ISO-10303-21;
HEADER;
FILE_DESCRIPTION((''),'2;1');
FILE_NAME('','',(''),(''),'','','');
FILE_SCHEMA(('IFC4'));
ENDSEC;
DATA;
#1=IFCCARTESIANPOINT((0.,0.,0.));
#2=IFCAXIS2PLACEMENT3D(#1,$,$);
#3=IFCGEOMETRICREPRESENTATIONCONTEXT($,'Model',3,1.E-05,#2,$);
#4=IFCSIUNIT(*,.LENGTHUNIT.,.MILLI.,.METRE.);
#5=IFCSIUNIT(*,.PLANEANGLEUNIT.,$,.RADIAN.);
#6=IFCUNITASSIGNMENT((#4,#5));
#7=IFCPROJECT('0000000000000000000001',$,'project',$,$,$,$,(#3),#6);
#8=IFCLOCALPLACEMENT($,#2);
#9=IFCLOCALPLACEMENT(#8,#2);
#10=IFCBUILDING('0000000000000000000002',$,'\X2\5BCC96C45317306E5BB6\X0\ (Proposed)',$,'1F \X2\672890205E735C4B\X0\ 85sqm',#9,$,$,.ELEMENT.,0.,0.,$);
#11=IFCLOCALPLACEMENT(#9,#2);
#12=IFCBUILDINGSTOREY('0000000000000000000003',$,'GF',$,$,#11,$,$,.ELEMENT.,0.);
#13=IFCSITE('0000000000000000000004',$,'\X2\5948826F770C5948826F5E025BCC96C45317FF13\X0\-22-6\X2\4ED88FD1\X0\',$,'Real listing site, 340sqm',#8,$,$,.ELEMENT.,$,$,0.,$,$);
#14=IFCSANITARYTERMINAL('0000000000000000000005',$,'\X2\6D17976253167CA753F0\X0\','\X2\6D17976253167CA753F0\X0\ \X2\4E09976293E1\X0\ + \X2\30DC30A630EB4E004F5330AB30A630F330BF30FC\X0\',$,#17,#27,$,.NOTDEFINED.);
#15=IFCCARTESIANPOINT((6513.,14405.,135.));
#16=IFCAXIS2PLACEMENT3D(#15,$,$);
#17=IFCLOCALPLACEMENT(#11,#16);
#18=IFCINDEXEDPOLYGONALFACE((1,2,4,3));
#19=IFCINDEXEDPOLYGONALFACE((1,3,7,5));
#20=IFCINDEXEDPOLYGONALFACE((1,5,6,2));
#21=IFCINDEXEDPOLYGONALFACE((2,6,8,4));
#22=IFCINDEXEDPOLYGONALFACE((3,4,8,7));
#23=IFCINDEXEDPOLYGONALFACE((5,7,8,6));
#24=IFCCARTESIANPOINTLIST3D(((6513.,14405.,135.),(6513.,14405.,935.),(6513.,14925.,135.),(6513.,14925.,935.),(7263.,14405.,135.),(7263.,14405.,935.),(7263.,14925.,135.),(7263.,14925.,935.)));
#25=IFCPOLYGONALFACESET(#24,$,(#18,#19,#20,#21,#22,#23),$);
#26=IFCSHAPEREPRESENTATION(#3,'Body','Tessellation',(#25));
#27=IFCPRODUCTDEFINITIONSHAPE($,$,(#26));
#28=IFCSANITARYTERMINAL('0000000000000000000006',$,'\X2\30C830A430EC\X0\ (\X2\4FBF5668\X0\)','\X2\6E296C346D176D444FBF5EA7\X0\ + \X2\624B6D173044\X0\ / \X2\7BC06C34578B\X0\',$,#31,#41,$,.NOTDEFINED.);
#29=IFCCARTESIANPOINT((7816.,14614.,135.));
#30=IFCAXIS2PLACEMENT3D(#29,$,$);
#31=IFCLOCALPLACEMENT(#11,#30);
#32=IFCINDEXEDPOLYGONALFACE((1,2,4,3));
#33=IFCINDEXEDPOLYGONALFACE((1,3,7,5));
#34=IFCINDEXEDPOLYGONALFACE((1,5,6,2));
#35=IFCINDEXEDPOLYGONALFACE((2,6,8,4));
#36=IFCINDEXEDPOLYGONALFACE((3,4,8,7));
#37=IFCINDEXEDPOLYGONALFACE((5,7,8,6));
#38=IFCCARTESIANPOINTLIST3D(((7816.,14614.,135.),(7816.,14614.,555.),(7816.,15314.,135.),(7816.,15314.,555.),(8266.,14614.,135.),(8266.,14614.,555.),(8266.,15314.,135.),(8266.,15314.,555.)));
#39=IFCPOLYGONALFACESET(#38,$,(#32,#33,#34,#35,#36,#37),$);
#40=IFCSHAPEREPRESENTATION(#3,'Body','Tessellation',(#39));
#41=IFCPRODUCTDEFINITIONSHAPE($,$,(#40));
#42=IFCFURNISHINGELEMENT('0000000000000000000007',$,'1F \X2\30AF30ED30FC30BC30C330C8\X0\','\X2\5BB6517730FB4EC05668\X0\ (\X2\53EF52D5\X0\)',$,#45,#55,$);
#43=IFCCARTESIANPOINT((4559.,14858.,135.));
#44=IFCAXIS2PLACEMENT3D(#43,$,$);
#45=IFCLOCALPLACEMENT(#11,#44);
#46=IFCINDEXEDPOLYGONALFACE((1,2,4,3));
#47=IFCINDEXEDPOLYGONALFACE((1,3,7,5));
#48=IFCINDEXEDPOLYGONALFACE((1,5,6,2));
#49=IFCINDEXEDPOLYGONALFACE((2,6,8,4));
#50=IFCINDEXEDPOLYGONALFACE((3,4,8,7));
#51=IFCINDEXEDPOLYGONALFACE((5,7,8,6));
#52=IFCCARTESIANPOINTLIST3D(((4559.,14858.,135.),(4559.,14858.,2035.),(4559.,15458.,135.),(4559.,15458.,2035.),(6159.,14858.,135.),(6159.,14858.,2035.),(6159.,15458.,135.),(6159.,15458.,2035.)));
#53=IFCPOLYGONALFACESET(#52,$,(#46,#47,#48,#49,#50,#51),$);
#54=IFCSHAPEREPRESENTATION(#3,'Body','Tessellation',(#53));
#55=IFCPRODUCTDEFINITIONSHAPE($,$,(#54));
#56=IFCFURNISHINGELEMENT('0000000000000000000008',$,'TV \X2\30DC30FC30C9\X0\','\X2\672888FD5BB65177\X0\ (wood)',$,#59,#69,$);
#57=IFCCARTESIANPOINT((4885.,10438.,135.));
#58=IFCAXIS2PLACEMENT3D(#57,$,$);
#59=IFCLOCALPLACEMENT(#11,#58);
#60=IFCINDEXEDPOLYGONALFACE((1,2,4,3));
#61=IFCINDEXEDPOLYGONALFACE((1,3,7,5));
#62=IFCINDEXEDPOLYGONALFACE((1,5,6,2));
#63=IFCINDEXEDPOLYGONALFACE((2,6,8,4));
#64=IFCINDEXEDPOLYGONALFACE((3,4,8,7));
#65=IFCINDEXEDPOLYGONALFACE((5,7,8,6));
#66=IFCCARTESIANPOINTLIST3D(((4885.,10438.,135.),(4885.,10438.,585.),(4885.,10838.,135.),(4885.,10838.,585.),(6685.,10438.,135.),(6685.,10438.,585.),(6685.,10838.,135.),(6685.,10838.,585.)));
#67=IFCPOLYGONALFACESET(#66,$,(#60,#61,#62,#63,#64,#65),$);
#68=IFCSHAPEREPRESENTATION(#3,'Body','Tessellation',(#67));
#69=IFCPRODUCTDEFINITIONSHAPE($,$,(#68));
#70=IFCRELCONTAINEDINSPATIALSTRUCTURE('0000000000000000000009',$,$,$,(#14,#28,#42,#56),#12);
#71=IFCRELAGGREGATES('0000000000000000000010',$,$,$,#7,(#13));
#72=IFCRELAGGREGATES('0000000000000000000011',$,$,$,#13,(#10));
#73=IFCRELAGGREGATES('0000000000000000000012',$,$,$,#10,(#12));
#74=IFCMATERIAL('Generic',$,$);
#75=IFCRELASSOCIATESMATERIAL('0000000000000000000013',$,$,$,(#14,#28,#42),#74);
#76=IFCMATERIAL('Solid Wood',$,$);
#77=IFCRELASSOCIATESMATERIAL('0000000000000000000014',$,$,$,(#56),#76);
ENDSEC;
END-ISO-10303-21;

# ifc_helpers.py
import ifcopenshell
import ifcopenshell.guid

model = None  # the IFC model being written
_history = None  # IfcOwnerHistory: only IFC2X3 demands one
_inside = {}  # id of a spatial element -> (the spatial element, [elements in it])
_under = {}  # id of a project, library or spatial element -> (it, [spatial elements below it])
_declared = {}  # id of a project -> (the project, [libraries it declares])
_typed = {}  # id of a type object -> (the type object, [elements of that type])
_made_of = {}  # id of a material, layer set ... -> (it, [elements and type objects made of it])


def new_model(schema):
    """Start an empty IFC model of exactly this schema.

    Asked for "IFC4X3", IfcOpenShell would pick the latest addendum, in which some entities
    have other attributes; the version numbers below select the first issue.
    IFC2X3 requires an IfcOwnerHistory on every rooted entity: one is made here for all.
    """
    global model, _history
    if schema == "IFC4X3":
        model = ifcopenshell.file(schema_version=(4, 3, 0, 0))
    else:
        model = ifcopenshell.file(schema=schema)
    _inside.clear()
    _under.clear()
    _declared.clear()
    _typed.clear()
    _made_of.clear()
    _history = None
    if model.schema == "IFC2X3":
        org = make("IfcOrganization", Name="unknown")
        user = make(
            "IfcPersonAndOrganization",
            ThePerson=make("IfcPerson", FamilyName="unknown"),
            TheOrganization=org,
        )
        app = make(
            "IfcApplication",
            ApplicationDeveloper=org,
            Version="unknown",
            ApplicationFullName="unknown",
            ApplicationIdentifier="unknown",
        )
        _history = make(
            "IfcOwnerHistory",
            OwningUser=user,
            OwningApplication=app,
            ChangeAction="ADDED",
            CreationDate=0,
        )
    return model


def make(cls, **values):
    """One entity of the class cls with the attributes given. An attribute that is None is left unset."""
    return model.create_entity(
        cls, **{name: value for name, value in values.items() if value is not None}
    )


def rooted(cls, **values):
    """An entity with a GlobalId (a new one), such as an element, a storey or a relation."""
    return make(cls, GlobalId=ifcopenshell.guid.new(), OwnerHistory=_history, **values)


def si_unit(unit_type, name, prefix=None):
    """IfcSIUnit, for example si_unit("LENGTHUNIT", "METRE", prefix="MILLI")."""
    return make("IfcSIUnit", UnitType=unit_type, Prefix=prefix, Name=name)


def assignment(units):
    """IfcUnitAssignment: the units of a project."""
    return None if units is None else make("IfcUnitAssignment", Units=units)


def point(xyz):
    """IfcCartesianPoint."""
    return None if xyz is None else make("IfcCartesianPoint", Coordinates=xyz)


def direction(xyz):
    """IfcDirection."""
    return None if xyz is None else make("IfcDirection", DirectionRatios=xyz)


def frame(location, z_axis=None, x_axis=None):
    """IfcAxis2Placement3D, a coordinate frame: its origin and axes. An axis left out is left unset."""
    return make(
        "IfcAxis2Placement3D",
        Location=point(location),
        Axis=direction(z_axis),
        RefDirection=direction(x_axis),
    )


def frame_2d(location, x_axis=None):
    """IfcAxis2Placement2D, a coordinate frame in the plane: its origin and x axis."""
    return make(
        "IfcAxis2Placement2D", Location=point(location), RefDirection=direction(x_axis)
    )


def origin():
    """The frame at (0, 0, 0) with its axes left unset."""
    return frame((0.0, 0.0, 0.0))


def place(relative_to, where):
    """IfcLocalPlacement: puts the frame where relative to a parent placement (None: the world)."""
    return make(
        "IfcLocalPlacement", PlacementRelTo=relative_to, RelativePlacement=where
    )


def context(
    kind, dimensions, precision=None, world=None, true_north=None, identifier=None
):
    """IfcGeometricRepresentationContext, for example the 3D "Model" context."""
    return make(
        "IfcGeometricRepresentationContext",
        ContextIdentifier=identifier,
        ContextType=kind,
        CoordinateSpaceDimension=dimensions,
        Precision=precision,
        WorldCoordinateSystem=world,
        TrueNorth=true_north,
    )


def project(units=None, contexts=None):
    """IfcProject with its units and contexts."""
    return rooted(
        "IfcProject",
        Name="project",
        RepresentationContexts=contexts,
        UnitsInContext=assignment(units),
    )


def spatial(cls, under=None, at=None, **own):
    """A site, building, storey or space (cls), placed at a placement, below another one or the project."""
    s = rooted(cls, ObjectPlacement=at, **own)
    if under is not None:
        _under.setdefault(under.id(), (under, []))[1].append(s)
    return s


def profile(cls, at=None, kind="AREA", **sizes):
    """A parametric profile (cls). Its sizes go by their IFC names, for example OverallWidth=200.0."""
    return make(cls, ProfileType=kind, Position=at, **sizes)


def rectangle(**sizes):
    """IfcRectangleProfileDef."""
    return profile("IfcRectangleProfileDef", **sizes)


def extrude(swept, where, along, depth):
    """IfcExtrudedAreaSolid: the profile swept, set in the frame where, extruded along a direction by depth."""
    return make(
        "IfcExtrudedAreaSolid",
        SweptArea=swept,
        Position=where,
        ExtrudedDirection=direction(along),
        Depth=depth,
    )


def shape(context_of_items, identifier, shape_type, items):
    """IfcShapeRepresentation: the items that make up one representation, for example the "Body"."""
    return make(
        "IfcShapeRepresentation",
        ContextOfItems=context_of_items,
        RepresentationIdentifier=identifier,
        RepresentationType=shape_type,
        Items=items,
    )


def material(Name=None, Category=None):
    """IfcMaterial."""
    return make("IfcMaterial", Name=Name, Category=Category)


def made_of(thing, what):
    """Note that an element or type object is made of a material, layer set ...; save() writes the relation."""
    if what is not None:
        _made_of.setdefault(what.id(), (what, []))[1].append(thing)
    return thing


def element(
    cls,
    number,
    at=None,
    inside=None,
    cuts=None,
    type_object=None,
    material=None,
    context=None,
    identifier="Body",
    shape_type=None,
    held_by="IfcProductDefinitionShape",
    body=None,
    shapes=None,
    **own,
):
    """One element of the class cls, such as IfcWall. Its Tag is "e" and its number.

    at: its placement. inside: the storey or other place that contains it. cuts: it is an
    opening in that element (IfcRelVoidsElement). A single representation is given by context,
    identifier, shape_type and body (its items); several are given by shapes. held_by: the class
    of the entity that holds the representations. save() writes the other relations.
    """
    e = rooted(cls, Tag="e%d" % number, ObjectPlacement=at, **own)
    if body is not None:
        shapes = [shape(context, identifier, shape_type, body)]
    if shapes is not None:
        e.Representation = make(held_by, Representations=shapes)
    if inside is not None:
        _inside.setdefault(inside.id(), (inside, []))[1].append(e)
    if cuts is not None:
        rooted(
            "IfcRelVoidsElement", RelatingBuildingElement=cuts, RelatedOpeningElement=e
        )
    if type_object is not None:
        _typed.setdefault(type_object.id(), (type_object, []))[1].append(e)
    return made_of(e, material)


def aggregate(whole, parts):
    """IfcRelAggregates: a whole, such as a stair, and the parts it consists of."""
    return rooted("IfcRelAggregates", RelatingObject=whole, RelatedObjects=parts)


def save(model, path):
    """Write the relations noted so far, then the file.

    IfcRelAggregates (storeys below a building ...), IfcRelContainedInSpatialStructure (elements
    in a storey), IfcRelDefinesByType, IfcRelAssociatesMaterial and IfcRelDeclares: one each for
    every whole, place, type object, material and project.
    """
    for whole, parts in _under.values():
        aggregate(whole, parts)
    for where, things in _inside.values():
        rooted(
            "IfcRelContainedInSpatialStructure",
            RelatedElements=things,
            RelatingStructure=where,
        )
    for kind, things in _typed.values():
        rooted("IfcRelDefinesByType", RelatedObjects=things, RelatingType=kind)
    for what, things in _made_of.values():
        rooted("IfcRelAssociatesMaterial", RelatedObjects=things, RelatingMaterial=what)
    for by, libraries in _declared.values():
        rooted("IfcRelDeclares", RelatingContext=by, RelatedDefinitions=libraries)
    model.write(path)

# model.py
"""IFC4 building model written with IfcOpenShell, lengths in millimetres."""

from ifc_helpers import new_model, si_unit, frame, frame_2d, origin, place, context, project, spatial, rectangle, extrude, material, element, save


model = new_model("IFC4")

# Units and contexts
model_context = context("Model", 3, precision=1e-05, world=origin())
ifc_project = project(units=[si_unit("LENGTHUNIT", "METRE", prefix="MILLI"), si_unit("PLANEANGLEUNIT", "RADIAN")], contexts=[model_context])

# Site, building, storey
site_placement = place(None, origin())
site = spatial("IfcSite", under=ifc_project, at=site_placement, Name="奈良県奈良市富雄北３-22-6付近", ObjectType="Real listing site, 340sqm", CompositionType="ELEMENT", RefElevation=0.0)
building_placement = place(site_placement, origin())
building = spatial("IfcBuilding", under=site, at=building_placement, Name="富雄北の家 (Proposed)", ObjectType="1F 木造平屋 85sqm", CompositionType="ELEMENT", ElevationOfRefHeight=0.0, ElevationOfTerrain=0.0)
storey_placement = place(building_placement, origin())
storey = spatial("IfcBuildingStorey", under=building, at=storey_placement, Name="GF", CompositionType="ELEMENT", Elevation=0.0)

# Shared definitions
ifc_material_1 = material(Name="Solid Wood")

# Shared definitions
ifc_material_2 = material(Name="Generic")

# Sanitary terminals
sanitary_terminal_1_placement = place(storey_placement, frame((6513.0, 14405.0, 135.0)))
element("IfcSanitaryTerminal", 1, at=sanitary_terminal_1_placement, inside=storey, material=ifc_material_2, Name="洗面化粧台", Description="洗面化粧台 三面鏡 + ボウル一体カウンター", PredefinedType="NOTDEFINED", context=model_context, shape_type="SweptSolid", body=[
    extrude(rectangle(XDim=750.0, YDim=520.0, at=frame_2d((375.0, 260.0))), frame((6513.0, 14405.0, 135.0)), (0.0, 0.0, 1.0), 800.0),
])
sanitary_terminal_2_placement = place(storey_placement, frame((7816.0, 14614.0, 135.0)))
element("IfcSanitaryTerminal", 2, at=sanitary_terminal_2_placement, inside=storey, material=ifc_material_2, Name="トイレ (便器)", Description="温水洗浄便座 + 手洗い / 節水型", PredefinedType="NOTDEFINED", context=model_context, shape_type="SweptSolid", body=[
    extrude(rectangle(XDim=450.0, YDim=700.0, at=frame_2d((225.0, 350.0))), frame((7816.0, 14614.0, 135.0)), (0.0, 0.0, 1.0), 420.0),
])

# Furnishing elements
furnishing_1_placement = place(storey_placement, frame((4559.0, 14858.0, 135.0)))
element("IfcFurnishingElement", 3, at=furnishing_1_placement, inside=storey, material=ifc_material_2, Name="1F クローゼット", Description="家具・什器 (可動)", context=model_context, shape_type="SweptSolid", body=[
    extrude(rectangle(XDim=1600.0, YDim=600.0, at=frame_2d((800.0, 300.0))), frame((4559.0, 14858.0, 135.0)), (0.0, 0.0, 1.0), 1900.0),
])
furnishing_2_placement = place(storey_placement, frame((4885.0, 10438.0, 135.0)))
element("IfcFurnishingElement", 4, at=furnishing_2_placement, inside=storey, material=ifc_material_1, Name="TV ボード", Description="木製家具 (wood)", context=model_context, shape_type="SweptSolid", body=[
    extrude(rectangle(XDim=1800.0, YDim=400.0, at=frame_2d((900.0, 200.0))), frame((4885.0, 10438.0, 135.0)), (0.0, 0.0, 1.0), 450.0),
])

save(model, "model.ifc")
